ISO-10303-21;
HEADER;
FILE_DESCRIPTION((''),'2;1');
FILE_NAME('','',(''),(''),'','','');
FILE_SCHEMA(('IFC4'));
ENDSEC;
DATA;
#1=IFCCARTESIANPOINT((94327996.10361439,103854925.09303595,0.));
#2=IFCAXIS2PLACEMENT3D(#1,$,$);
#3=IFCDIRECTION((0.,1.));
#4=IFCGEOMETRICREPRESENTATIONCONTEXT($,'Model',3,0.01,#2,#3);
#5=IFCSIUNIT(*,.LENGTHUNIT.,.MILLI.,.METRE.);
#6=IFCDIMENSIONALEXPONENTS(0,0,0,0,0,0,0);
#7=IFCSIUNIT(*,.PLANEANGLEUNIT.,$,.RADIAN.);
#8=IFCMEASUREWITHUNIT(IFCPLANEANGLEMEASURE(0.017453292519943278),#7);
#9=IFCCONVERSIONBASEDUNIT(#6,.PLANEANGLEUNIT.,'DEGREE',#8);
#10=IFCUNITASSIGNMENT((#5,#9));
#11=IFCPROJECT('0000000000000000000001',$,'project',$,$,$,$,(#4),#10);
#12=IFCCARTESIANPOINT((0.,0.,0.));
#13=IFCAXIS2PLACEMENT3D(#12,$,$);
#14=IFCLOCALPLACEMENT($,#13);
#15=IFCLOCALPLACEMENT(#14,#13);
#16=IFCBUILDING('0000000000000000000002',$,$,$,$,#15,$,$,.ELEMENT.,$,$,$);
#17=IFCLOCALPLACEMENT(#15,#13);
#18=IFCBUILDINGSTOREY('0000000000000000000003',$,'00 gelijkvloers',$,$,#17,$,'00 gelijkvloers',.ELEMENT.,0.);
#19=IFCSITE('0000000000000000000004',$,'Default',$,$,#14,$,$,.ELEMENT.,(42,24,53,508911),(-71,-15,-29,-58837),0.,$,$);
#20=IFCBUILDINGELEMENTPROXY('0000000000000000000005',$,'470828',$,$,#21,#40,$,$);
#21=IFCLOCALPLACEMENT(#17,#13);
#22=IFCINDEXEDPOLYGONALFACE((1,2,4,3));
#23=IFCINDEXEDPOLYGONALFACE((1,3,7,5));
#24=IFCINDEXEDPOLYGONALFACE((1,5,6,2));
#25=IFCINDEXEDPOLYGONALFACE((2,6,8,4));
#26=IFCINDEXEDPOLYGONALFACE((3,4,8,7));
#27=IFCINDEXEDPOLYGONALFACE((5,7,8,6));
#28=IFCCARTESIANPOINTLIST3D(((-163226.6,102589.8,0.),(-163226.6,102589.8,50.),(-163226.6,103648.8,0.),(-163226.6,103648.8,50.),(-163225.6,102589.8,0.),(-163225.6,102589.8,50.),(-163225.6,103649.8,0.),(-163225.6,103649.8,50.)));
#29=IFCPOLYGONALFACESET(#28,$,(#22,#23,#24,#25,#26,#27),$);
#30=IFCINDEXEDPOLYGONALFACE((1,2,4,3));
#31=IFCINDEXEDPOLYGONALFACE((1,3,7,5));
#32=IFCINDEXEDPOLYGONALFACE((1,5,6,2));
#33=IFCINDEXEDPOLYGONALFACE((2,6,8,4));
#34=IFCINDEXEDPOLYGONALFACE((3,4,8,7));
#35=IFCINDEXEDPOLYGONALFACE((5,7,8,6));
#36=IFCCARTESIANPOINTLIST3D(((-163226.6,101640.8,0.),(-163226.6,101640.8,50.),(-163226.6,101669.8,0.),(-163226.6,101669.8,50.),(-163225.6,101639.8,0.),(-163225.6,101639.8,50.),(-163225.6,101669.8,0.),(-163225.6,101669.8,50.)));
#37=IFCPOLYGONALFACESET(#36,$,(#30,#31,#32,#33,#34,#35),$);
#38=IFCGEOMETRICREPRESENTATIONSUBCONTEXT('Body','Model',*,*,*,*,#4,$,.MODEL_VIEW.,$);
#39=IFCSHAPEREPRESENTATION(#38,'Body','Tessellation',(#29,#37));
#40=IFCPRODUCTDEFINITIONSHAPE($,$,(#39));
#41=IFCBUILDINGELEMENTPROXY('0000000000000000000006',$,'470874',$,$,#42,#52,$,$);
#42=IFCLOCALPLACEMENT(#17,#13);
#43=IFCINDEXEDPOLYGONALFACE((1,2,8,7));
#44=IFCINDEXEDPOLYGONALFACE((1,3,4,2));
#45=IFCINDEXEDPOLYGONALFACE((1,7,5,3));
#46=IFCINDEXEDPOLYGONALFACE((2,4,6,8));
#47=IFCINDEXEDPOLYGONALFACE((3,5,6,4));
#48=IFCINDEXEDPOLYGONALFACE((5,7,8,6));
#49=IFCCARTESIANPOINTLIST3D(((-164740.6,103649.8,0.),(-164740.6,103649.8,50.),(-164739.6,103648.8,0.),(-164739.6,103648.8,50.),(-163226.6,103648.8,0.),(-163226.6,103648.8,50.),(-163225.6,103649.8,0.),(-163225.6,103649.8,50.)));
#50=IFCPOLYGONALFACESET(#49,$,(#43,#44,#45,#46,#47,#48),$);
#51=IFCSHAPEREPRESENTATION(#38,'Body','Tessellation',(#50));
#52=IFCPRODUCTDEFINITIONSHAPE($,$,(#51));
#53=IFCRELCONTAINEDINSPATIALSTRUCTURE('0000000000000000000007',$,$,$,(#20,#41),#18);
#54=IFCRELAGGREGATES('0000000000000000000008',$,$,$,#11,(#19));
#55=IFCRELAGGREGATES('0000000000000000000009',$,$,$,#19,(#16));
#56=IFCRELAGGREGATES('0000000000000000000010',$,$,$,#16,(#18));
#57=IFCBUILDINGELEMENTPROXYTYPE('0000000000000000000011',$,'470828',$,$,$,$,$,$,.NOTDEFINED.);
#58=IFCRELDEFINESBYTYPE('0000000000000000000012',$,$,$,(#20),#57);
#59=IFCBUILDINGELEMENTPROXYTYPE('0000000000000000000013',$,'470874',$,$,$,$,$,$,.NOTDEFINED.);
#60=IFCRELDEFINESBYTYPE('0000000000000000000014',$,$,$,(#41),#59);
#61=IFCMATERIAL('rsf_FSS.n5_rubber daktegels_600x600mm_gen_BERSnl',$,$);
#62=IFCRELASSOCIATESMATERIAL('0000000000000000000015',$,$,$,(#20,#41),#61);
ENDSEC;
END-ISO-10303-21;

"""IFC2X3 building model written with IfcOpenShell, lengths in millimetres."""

from ifc_helpers import new_model, entity, si_unit, converted_unit, direction, frame, origin, place, context, subcontext, project, spatial, polyline, outline, extrude, material, type_object, element, save


model = new_model("IFC2X3")

# Units and contexts
model_context = context("Model", 3, precision=0.01, world=frame((94327996.10361439, 103854925.09303595, 0.0)), true_north=direction((0.0, 1.0)))
body_context = subcontext(model_context, "Body", "Model", "MODEL_VIEW")
ifc_project = project(units=[si_unit("LENGTHUNIT", "METRE", prefix="MILLI"), converted_unit("PLANEANGLEUNIT", "DEGREE", entity("IfcPlaneAngleMeasure", 0.017453292519943278), si_unit("PLANEANGLEUNIT", "RADIAN"), dimensions=[0, 0, 0, 0, 0, 0, 0])], contexts=[model_context])

# Site, building, storey
site_placement = place(None, origin())
site = spatial("IfcSite", under=ifc_project, at=site_placement, Name="Default", CompositionType="ELEMENT", RefLatitude=(42, 24, 53, 508911), RefLongitude=(-71, -15, -29, -58837), RefElevation=0.0)
building_placement = place(site_placement, origin())
building = spatial("IfcBuilding", under=site, at=building_placement, CompositionType="ELEMENT")
storey_placement = place(building_placement, origin())
storey = spatial("IfcBuildingStorey", under=building, at=storey_placement, Name="00 gelijkvloers", LongName="00 gelijkvloers", CompositionType="ELEMENT", Elevation=0.0)

# Building element proxies
ifc_material_1 = material(Name="rsf_FSS.n5_rubber daktegels_600x600mm_gen_BERSnl")
building_element_proxy_type_1 = type_object("IfcBuildingElementProxyType", Name="470828", PredefinedType="NOTDEFINED")
proxy_1_placement = place(storey_placement, origin())
element("IfcBuildingElementProxy", 1, at=proxy_1_placement, inside=storey, type_object=building_element_proxy_type_1, material=ifc_material_1, Name="470828", context=body_context, shape_type="SweptSolid", body=[
    extrude(outline(polyline([(-529.8, -0.5), (530.3, -0.5), (529.3, 0.5), (-529.8, 0.5), (-529.8, -0.5)])), frame((-163226.1, 103119.5, 0.0), z_axis=(0.0, 0.0, 1.0), x_axis=(0.0, 1.0, 0.0)), (0.0, 0.0, 1.0), 50.0),
    extrude(outline(polyline([(-15.2, -0.5), (14.7, -0.5), (14.7, 0.5), (-14.2, 0.5), (-15.2, -0.5)])), frame((-163226.1, 101655.0, 0.0), z_axis=(0.0, 0.0, 1.0), x_axis=(0.0, 1.0, 0.0)), (0.0, 0.0, 1.0), 50.0),
])
building_element_proxy_type_2 = type_object("IfcBuildingElementProxyType", Name="470874", PredefinedType="NOTDEFINED")
proxy_2_placement = place(storey_placement, origin())
element("IfcBuildingElementProxy", 2, at=proxy_2_placement, inside=storey, type_object=building_element_proxy_type_2, material=ifc_material_1, Name="470874", context=body_context, shape_type="SweptSolid", body=[
    extrude(outline(polyline([(-757.5, -0.5), (757.5, -0.5), (756.5, 0.5), (-756.5, 0.5), (-757.5, -0.5)])), frame((-163983.1, 103649.3, 0.0), z_axis=(0.0, 0.0, 1.0), x_axis=(-1.0, 0.0, 0.0)), (0.0, 0.0, 1.0), 50.0),
])

save(model, "model.ifc")
